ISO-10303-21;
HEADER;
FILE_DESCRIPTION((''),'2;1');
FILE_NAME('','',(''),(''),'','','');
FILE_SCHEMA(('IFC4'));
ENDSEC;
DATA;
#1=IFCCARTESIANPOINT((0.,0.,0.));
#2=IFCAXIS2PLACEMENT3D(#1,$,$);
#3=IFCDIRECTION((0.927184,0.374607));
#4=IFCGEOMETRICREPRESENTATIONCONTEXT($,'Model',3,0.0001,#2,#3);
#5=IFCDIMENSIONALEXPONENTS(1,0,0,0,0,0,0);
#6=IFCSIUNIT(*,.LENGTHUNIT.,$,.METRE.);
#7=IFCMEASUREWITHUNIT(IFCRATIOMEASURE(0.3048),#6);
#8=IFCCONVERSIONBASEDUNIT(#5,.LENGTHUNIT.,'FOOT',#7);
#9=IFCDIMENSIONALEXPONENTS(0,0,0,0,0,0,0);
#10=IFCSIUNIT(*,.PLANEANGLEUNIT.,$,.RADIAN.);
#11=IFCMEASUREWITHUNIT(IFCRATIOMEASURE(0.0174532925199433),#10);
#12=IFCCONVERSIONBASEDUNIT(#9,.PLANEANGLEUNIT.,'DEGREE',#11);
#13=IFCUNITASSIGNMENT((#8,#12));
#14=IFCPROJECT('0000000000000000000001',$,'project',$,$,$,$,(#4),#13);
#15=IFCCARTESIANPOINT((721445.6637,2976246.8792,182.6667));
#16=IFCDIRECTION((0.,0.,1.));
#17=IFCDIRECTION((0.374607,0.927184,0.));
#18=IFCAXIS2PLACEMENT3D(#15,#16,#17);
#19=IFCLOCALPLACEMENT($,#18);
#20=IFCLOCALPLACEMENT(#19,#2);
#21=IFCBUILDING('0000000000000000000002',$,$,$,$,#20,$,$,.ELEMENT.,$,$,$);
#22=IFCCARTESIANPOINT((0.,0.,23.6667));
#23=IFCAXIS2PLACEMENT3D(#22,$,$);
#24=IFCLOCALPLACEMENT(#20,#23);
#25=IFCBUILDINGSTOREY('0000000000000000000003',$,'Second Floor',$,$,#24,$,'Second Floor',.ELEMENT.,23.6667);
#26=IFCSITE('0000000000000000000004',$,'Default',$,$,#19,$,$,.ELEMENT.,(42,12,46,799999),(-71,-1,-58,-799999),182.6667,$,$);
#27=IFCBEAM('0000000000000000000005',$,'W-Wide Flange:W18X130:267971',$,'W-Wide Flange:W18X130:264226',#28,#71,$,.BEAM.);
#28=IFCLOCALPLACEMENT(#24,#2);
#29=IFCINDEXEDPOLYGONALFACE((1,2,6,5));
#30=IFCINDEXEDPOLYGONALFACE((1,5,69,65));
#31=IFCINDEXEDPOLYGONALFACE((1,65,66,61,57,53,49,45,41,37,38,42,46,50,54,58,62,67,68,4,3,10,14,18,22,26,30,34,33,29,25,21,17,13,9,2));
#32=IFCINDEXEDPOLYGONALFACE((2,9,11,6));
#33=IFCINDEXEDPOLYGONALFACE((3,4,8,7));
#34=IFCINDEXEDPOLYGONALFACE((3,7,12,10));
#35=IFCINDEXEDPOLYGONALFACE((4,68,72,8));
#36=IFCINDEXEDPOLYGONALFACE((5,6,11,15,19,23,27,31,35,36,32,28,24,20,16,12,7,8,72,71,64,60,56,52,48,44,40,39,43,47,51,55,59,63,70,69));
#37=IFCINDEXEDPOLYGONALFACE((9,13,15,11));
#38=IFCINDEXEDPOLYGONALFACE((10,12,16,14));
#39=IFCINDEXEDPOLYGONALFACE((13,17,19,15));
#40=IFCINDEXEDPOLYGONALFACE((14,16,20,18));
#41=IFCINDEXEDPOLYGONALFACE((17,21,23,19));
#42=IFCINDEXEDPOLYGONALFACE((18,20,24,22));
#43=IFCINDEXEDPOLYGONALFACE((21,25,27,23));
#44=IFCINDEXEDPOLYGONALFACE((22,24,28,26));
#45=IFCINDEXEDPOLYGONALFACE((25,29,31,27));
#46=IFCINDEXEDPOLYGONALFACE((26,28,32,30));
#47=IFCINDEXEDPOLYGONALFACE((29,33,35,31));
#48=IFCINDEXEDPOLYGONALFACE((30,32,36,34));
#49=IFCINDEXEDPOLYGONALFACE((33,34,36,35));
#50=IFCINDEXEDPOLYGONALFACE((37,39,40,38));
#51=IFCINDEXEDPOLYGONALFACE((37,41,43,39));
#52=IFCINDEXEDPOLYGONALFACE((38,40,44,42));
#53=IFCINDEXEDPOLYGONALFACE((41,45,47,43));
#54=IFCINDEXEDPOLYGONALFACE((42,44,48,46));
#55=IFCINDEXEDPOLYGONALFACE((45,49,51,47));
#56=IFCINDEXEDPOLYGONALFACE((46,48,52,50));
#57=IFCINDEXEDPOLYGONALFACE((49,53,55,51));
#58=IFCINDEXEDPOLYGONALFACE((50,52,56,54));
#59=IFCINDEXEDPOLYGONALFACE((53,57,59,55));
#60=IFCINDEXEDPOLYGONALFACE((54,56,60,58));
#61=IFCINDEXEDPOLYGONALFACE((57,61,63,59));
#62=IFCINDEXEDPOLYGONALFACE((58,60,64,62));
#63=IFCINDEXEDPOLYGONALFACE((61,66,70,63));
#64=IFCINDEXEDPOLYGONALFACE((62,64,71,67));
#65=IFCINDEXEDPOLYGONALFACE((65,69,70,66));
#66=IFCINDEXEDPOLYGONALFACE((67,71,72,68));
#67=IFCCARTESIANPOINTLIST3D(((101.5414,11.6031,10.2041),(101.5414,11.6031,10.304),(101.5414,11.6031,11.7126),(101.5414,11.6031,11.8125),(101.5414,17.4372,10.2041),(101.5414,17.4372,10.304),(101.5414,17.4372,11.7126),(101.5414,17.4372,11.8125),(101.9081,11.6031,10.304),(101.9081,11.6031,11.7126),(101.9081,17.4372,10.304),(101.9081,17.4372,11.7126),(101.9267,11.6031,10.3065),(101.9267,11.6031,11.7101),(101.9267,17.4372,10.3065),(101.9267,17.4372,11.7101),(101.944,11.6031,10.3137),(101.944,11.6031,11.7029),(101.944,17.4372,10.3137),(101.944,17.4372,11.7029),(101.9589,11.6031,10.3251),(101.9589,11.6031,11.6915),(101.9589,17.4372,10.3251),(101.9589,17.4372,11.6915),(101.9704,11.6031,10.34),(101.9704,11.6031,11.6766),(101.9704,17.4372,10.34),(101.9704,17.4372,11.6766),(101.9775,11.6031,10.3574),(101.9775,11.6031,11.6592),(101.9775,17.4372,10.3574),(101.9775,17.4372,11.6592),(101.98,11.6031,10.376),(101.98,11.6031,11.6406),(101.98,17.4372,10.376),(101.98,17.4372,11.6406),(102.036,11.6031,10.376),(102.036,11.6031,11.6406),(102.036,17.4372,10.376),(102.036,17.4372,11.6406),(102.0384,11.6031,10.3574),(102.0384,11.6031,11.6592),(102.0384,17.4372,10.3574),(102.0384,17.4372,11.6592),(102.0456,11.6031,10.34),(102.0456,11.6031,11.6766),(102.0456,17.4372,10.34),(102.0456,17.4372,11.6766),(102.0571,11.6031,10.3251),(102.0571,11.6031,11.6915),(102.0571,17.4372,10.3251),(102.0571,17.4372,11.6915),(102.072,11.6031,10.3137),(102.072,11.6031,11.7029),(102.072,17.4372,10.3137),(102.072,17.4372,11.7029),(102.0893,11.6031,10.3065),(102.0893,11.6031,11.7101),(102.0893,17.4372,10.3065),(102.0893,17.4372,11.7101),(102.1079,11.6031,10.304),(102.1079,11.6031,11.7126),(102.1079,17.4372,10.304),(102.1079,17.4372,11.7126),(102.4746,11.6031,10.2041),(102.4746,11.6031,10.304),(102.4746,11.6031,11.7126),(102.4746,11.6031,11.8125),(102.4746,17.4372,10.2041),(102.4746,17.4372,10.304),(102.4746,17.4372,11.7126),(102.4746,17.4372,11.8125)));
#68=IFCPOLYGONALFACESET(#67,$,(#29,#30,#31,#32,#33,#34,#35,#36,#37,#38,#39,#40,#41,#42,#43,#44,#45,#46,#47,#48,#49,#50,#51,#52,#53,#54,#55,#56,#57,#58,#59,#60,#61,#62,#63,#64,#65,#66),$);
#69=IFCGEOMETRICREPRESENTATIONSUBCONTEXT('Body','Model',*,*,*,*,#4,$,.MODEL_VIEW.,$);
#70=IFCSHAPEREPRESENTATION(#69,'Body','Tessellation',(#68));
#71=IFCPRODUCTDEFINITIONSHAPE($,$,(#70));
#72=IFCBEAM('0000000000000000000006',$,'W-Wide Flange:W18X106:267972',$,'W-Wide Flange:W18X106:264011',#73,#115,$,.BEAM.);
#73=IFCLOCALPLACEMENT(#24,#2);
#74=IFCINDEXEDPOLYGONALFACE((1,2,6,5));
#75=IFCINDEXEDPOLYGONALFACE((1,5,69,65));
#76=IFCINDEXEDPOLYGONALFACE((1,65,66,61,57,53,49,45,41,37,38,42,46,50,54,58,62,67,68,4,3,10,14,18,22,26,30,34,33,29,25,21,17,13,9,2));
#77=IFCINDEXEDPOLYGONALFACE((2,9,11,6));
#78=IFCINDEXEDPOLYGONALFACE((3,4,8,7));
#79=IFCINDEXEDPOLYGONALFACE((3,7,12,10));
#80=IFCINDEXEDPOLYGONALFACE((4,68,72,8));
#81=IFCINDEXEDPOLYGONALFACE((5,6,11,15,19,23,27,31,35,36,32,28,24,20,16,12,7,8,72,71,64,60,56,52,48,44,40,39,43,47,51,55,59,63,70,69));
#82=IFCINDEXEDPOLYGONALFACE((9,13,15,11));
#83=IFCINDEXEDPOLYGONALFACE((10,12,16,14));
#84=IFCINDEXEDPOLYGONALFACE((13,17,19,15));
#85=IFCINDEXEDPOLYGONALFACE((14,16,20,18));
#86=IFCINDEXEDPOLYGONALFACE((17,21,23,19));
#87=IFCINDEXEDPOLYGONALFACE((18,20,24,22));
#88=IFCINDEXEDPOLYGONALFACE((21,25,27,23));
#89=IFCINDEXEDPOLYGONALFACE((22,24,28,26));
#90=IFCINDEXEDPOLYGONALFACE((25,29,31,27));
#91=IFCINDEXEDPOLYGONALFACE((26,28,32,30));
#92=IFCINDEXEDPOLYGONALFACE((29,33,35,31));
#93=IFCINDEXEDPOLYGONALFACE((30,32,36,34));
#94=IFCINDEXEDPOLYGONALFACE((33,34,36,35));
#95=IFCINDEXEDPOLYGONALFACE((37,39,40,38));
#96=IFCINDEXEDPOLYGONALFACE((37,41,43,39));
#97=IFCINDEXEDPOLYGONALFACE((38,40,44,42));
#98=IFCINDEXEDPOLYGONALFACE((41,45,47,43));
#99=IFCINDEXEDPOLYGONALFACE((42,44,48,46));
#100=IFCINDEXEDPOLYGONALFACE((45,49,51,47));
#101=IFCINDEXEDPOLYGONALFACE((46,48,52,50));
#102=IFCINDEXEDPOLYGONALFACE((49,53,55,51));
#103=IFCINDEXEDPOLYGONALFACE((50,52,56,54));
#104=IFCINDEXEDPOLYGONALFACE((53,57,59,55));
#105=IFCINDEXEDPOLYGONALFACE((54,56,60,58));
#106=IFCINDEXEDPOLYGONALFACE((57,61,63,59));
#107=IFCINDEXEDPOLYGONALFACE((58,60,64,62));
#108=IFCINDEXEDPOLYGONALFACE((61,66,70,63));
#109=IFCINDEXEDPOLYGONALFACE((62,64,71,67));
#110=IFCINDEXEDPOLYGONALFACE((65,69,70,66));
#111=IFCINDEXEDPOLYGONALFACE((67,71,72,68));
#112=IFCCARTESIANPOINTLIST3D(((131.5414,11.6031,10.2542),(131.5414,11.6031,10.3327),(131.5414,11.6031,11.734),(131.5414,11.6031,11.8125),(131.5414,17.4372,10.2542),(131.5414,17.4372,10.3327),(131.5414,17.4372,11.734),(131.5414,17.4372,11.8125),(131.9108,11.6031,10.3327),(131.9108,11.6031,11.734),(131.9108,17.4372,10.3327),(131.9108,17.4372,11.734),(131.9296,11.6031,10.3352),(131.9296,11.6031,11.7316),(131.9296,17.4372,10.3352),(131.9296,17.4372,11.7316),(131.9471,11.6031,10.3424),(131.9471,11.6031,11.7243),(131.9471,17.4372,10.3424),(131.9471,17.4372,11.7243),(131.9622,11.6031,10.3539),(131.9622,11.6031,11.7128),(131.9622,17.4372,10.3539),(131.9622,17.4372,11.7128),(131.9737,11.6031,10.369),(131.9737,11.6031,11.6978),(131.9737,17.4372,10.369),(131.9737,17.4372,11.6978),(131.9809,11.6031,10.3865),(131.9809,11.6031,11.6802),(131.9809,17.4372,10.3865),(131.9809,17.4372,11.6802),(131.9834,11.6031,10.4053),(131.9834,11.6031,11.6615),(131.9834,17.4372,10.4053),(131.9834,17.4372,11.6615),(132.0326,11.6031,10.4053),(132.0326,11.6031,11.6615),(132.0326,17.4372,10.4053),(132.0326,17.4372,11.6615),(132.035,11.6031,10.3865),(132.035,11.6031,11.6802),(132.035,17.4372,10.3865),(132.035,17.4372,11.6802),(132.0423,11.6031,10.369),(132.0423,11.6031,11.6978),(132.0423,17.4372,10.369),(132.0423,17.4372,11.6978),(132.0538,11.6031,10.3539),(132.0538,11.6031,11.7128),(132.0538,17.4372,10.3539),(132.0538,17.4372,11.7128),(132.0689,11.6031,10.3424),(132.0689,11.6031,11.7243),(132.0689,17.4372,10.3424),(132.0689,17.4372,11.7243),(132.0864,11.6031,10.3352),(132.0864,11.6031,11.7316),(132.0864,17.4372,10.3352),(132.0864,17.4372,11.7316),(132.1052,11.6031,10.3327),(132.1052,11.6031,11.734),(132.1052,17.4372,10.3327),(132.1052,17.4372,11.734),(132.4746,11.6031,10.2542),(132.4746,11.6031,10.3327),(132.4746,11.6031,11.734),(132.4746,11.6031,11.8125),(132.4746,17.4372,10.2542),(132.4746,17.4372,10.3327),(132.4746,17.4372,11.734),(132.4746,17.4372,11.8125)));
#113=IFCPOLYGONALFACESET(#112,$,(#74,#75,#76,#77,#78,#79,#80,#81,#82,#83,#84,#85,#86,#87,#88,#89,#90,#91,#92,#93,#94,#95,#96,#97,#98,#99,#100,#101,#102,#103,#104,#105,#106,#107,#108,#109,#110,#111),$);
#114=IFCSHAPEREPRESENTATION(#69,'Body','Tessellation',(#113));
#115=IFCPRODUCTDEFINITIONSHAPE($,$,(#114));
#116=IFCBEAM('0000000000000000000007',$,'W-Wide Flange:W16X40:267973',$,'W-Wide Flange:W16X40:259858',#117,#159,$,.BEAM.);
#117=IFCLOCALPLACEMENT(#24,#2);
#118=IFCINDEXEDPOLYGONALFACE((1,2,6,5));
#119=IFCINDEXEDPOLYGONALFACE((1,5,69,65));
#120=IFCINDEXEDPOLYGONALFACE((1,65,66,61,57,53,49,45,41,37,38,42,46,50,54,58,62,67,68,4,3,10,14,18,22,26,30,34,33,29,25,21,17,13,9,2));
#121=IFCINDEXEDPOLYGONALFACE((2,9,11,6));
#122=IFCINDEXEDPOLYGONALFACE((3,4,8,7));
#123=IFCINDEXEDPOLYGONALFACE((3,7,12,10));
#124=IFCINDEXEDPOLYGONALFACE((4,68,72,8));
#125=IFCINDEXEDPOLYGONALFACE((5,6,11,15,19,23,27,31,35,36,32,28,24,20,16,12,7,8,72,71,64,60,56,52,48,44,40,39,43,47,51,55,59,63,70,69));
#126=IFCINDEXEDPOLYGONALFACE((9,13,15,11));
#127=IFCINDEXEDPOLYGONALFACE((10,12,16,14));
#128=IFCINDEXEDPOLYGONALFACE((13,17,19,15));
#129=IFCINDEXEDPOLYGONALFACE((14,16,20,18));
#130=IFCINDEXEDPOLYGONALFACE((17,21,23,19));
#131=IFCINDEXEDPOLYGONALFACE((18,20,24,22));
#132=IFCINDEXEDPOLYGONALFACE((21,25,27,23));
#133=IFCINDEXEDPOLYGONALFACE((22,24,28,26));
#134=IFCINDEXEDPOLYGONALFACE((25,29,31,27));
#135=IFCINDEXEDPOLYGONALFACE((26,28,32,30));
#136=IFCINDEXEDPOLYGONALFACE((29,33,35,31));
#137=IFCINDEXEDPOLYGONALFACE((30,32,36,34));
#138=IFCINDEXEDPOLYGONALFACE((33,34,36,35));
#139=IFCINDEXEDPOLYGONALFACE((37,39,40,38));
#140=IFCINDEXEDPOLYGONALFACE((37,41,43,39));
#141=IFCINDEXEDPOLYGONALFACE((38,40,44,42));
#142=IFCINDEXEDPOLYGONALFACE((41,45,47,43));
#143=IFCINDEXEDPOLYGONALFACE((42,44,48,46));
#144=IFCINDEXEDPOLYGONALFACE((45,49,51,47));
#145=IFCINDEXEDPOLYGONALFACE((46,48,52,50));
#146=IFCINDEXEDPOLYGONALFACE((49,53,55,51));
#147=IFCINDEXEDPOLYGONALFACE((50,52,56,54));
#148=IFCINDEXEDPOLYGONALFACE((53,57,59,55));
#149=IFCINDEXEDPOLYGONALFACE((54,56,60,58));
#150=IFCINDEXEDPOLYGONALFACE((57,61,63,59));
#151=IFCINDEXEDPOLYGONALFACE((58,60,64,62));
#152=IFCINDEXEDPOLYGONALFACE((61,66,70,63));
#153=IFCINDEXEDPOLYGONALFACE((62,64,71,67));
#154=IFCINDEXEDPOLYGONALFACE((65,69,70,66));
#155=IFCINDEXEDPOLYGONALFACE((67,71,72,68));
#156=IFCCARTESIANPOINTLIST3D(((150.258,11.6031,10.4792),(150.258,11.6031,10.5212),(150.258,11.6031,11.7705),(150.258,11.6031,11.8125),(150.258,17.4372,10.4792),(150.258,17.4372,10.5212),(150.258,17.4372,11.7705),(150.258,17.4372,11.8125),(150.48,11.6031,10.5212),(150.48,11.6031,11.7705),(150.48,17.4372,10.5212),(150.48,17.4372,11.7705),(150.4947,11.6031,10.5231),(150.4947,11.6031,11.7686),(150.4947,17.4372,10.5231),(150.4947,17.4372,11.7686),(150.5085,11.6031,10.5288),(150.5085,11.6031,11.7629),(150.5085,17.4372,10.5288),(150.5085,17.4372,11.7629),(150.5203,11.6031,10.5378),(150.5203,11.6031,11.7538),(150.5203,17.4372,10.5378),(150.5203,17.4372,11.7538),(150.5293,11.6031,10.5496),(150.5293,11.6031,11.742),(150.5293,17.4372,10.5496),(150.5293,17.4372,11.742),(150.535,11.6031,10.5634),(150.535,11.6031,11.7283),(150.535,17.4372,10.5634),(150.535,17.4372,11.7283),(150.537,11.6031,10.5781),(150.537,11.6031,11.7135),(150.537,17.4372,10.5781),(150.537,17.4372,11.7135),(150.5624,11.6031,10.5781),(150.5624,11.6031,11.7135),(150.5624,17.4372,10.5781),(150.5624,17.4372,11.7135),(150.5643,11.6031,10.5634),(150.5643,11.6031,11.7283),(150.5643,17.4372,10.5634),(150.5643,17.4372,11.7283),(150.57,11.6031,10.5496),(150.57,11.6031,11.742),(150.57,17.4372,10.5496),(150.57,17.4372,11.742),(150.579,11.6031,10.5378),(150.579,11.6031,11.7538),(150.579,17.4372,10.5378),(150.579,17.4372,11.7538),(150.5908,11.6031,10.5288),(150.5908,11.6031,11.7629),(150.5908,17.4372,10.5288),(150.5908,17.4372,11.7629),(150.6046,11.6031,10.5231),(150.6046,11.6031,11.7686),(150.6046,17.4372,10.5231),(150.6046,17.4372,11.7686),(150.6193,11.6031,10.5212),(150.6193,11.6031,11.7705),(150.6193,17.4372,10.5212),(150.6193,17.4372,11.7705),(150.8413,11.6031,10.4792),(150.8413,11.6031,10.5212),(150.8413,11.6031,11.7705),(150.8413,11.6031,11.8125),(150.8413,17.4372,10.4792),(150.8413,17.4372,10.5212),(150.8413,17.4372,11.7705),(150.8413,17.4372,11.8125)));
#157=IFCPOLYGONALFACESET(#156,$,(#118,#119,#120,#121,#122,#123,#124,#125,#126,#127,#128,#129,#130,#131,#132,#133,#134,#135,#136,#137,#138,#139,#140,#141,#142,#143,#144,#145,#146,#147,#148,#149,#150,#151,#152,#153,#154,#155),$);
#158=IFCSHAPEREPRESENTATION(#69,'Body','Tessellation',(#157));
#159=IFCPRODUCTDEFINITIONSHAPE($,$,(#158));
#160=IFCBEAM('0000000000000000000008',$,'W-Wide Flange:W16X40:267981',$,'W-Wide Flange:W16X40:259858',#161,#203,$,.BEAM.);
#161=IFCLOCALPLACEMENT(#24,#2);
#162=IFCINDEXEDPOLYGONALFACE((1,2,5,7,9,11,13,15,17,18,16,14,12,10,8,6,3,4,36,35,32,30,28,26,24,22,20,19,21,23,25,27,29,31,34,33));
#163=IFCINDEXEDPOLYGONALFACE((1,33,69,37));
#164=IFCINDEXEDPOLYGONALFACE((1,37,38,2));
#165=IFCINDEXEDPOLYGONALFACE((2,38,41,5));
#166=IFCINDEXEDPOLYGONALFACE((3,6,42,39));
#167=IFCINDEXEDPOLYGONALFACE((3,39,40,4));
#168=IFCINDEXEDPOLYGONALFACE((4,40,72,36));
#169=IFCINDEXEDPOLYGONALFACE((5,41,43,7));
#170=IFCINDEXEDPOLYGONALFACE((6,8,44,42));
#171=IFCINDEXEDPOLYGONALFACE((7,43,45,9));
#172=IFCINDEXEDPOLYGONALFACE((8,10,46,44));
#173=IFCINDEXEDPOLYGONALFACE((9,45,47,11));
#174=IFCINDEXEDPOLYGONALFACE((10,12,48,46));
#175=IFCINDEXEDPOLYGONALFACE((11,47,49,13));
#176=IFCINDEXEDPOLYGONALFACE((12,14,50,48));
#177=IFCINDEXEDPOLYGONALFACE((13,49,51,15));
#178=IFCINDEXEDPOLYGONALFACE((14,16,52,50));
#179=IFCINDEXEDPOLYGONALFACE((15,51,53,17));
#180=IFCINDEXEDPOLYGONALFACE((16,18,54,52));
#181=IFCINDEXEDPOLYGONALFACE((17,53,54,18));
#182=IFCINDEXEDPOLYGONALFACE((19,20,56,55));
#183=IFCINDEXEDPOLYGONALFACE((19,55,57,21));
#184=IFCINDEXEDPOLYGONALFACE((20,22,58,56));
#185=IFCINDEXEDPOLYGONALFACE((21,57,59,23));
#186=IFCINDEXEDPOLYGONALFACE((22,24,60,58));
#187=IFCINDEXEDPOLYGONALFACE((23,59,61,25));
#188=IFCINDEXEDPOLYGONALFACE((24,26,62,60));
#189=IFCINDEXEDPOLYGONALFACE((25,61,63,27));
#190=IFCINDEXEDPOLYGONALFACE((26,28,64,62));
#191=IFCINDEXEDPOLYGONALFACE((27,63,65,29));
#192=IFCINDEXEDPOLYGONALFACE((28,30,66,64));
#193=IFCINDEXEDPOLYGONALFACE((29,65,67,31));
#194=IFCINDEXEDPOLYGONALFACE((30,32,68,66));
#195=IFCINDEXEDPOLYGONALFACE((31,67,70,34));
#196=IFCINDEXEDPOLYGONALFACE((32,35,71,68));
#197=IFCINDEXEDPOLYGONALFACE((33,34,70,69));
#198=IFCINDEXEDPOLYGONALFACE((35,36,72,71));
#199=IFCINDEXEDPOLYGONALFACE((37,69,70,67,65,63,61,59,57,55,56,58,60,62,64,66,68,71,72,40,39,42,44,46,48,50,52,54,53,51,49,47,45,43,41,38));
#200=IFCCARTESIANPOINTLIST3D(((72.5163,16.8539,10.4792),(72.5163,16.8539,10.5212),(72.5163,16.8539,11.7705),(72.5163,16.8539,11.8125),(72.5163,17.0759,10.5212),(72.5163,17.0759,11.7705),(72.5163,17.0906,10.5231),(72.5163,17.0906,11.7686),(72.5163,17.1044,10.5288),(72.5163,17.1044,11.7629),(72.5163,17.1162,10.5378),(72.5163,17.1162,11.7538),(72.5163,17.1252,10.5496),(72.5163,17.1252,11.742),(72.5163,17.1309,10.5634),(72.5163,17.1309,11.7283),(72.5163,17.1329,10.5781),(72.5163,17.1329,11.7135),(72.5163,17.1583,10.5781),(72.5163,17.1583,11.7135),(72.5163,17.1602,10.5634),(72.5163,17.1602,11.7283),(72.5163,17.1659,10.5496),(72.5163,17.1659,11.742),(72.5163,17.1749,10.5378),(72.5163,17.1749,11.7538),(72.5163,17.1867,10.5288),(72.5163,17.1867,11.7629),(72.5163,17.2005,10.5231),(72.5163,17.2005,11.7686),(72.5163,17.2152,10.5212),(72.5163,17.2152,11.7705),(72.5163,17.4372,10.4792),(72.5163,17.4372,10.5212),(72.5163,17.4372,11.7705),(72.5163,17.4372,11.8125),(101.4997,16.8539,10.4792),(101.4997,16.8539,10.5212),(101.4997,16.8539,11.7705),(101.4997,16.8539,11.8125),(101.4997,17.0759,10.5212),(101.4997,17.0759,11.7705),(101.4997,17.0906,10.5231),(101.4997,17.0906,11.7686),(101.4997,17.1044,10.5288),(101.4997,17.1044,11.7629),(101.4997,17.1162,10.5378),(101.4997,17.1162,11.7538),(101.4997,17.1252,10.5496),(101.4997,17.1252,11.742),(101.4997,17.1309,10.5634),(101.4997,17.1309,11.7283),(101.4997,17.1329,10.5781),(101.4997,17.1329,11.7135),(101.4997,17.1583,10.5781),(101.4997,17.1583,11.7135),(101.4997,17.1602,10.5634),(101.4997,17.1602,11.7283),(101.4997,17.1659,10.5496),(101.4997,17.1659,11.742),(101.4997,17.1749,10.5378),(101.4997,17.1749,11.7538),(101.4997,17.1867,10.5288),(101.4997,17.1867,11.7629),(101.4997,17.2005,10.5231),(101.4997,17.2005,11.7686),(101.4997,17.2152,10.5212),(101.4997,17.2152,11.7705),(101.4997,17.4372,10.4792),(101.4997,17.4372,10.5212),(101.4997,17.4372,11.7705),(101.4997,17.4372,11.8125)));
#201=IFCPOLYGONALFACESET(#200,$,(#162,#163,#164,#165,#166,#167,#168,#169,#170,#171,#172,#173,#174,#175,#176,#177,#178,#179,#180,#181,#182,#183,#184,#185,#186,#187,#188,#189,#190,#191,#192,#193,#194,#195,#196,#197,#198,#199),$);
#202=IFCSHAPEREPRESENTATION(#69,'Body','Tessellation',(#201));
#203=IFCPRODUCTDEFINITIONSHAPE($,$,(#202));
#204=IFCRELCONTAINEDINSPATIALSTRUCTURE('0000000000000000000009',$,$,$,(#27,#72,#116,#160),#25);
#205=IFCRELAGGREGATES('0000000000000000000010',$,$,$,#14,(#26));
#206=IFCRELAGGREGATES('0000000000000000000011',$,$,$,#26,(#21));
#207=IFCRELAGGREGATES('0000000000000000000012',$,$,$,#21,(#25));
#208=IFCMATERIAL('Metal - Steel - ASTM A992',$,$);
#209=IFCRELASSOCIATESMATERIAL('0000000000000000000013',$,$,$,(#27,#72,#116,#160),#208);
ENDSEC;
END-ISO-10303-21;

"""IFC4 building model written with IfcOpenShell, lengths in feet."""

from ifc_helpers import new_model, entity, si_unit, converted_unit, direction, frame, frame_2d, origin, place, context, subcontext, project, spatial, i_section, extrude, material, element, save


model = new_model("IFC4")

# Units and contexts
model_context = context("Model", 3, precision=0.0001, world=origin(), true_north=direction((0.927184, 0.374607)))
body_context = subcontext(model_context, "Body", "Model", "MODEL_VIEW")
ifc_project = project(units=[converted_unit("LENGTHUNIT", "FOOT", entity("IfcRatioMeasure", 0.3048), si_unit("LENGTHUNIT", "METRE"), dimensions=[1, 0, 0, 0, 0, 0, 0]), converted_unit("PLANEANGLEUNIT", "DEGREE", entity("IfcRatioMeasure", 0.0174532925199433), si_unit("PLANEANGLEUNIT", "RADIAN"), dimensions=[0, 0, 0, 0, 0, 0, 0])], contexts=[model_context])

# Site, building, storey
site_placement = place(None, frame((721445.6637, 2976246.8792, 182.6667), z_axis=(0.0, 0.0, 1.0), x_axis=(0.374607, 0.927184, 0.0)))
site = spatial("IfcSite", under=ifc_project, at=site_placement, Name="Default", CompositionType="ELEMENT", RefLatitude=(42, 12, 46, 799999), RefLongitude=(-71, -1, -58, -799999), RefElevation=182.6667)
building_placement = place(site_placement, origin())
building = spatial("IfcBuilding", under=site, at=building_placement, CompositionType="ELEMENT")
storey_placement = place(building_placement, frame((0.0, 0.0, 23.6667)))
storey = spatial("IfcBuildingStorey", under=building, at=storey_placement, Name="Second Floor", LongName="Second Floor", CompositionType="ELEMENT", Elevation=23.6667)

# Shared definitions
ifc_material_1 = material(Name="Metal - Steel - ASTM A992")

# Beams
beam_1_placement = place(storey_placement, frame((102.008, 11.1456, 11.8125), z_axis=(0.0, 0.0, 1.0), x_axis=(0.0, 1.0, 0.0)))
element("IfcBeam", 1, at=beam_1_placement, inside=storey, material=ifc_material_1, Name="W-Wide Flange:W18X130:267971", ObjectType="W-Wide Flange:W18X130:264226", PredefinedType="BEAM", context=body_context, shape_type="SweptSolid", body=[
    extrude(i_section(OverallWidth=0.9333, OverallDepth=1.6084, WebThickness=0.056, FlangeThickness=0.0999, FilletRadius=0.0719, at=frame_2d((0.0, 0.0), x_axis=(0.0, 1.0))), frame((0.4575, 0.0, -0.8042), z_axis=(1.0, 0.0, 0.0), x_axis=(0.0, 0.0, -1.0)), (0.0, 0.0, 1.0), 5.8341),
])
beam_2_placement = place(storey_placement, frame((132.008, 11.1456, 11.8125), z_axis=(0.0, 0.0, 1.0), x_axis=(0.0, 1.0, 0.0)))
element("IfcBeam", 2, at=beam_2_placement, inside=storey, material=ifc_material_1, Name="W-Wide Flange:W18X106:267972", ObjectType="W-Wide Flange:W18X106:264011", PredefinedType="BEAM", context=body_context, shape_type="SweptSolid", body=[
    extrude(i_section(OverallWidth=0.9333, OverallDepth=1.5583, WebThickness=0.0492, FlangeThickness=0.0785, FilletRadius=0.0726, at=frame_2d((0.0, 0.0), x_axis=(0.0, 1.0))), frame((0.4575, 0.0, -0.7791), z_axis=(1.0, 0.0, 0.0), x_axis=(0.0, 0.0, -1.0)), (0.0, 0.0, 1.0), 5.8341),
])
beam_3_placement = place(storey_placement, frame((150.5497, 11.1456, 11.8125), z_axis=(0.0, 0.0, 1.0), x_axis=(0.0, 1.0, 0.0)))
element("IfcBeam", 3, at=beam_3_placement, inside=storey, material=ifc_material_1, Name="W-Wide Flange:W16X40:267973", ObjectType="W-Wide Flange:W16X40:259858", PredefinedType="BEAM", context=body_context, shape_type="SweptSolid", body=[
    extrude(i_section(OverallWidth=0.5833, OverallDepth=1.3333, WebThickness=0.0254, FlangeThickness=0.042, FilletRadius=0.057, at=frame_2d((0.0, 0.0), x_axis=(0.0, 1.0))), frame((0.4575, 0.0, -0.6667), z_axis=(1.0, 0.0, 0.0), x_axis=(0.0, 0.0, -1.0)), (0.0, 0.0, 1.0), 5.8341),
])
beam_4_placement = place(storey_placement, frame((102.008, 17.1456, 11.8125), z_axis=(0.0, 0.0, 1.0), x_axis=(-1.0, 0.0, 0.0)))
element("IfcBeam", 4, at=beam_4_placement, inside=storey, material=ifc_material_1, Name="W-Wide Flange:W16X40:267981", ObjectType="W-Wide Flange:W16X40:259858", PredefinedType="BEAM", context=body_context, shape_type="SweptSolid", body=[
    extrude(i_section(OverallWidth=0.5833, OverallDepth=1.3333, WebThickness=0.0254, FlangeThickness=0.042, FilletRadius=0.057, at=frame_2d((0.0, 0.0), x_axis=(0.0, 1.0))), frame((0.5083, 0.0, -0.6667), z_axis=(1.0, 0.0, 0.0), x_axis=(0.0, 0.0, -1.0)), (0.0, 0.0, 1.0), 28.9834),
])

save(model, "model.ifc")
